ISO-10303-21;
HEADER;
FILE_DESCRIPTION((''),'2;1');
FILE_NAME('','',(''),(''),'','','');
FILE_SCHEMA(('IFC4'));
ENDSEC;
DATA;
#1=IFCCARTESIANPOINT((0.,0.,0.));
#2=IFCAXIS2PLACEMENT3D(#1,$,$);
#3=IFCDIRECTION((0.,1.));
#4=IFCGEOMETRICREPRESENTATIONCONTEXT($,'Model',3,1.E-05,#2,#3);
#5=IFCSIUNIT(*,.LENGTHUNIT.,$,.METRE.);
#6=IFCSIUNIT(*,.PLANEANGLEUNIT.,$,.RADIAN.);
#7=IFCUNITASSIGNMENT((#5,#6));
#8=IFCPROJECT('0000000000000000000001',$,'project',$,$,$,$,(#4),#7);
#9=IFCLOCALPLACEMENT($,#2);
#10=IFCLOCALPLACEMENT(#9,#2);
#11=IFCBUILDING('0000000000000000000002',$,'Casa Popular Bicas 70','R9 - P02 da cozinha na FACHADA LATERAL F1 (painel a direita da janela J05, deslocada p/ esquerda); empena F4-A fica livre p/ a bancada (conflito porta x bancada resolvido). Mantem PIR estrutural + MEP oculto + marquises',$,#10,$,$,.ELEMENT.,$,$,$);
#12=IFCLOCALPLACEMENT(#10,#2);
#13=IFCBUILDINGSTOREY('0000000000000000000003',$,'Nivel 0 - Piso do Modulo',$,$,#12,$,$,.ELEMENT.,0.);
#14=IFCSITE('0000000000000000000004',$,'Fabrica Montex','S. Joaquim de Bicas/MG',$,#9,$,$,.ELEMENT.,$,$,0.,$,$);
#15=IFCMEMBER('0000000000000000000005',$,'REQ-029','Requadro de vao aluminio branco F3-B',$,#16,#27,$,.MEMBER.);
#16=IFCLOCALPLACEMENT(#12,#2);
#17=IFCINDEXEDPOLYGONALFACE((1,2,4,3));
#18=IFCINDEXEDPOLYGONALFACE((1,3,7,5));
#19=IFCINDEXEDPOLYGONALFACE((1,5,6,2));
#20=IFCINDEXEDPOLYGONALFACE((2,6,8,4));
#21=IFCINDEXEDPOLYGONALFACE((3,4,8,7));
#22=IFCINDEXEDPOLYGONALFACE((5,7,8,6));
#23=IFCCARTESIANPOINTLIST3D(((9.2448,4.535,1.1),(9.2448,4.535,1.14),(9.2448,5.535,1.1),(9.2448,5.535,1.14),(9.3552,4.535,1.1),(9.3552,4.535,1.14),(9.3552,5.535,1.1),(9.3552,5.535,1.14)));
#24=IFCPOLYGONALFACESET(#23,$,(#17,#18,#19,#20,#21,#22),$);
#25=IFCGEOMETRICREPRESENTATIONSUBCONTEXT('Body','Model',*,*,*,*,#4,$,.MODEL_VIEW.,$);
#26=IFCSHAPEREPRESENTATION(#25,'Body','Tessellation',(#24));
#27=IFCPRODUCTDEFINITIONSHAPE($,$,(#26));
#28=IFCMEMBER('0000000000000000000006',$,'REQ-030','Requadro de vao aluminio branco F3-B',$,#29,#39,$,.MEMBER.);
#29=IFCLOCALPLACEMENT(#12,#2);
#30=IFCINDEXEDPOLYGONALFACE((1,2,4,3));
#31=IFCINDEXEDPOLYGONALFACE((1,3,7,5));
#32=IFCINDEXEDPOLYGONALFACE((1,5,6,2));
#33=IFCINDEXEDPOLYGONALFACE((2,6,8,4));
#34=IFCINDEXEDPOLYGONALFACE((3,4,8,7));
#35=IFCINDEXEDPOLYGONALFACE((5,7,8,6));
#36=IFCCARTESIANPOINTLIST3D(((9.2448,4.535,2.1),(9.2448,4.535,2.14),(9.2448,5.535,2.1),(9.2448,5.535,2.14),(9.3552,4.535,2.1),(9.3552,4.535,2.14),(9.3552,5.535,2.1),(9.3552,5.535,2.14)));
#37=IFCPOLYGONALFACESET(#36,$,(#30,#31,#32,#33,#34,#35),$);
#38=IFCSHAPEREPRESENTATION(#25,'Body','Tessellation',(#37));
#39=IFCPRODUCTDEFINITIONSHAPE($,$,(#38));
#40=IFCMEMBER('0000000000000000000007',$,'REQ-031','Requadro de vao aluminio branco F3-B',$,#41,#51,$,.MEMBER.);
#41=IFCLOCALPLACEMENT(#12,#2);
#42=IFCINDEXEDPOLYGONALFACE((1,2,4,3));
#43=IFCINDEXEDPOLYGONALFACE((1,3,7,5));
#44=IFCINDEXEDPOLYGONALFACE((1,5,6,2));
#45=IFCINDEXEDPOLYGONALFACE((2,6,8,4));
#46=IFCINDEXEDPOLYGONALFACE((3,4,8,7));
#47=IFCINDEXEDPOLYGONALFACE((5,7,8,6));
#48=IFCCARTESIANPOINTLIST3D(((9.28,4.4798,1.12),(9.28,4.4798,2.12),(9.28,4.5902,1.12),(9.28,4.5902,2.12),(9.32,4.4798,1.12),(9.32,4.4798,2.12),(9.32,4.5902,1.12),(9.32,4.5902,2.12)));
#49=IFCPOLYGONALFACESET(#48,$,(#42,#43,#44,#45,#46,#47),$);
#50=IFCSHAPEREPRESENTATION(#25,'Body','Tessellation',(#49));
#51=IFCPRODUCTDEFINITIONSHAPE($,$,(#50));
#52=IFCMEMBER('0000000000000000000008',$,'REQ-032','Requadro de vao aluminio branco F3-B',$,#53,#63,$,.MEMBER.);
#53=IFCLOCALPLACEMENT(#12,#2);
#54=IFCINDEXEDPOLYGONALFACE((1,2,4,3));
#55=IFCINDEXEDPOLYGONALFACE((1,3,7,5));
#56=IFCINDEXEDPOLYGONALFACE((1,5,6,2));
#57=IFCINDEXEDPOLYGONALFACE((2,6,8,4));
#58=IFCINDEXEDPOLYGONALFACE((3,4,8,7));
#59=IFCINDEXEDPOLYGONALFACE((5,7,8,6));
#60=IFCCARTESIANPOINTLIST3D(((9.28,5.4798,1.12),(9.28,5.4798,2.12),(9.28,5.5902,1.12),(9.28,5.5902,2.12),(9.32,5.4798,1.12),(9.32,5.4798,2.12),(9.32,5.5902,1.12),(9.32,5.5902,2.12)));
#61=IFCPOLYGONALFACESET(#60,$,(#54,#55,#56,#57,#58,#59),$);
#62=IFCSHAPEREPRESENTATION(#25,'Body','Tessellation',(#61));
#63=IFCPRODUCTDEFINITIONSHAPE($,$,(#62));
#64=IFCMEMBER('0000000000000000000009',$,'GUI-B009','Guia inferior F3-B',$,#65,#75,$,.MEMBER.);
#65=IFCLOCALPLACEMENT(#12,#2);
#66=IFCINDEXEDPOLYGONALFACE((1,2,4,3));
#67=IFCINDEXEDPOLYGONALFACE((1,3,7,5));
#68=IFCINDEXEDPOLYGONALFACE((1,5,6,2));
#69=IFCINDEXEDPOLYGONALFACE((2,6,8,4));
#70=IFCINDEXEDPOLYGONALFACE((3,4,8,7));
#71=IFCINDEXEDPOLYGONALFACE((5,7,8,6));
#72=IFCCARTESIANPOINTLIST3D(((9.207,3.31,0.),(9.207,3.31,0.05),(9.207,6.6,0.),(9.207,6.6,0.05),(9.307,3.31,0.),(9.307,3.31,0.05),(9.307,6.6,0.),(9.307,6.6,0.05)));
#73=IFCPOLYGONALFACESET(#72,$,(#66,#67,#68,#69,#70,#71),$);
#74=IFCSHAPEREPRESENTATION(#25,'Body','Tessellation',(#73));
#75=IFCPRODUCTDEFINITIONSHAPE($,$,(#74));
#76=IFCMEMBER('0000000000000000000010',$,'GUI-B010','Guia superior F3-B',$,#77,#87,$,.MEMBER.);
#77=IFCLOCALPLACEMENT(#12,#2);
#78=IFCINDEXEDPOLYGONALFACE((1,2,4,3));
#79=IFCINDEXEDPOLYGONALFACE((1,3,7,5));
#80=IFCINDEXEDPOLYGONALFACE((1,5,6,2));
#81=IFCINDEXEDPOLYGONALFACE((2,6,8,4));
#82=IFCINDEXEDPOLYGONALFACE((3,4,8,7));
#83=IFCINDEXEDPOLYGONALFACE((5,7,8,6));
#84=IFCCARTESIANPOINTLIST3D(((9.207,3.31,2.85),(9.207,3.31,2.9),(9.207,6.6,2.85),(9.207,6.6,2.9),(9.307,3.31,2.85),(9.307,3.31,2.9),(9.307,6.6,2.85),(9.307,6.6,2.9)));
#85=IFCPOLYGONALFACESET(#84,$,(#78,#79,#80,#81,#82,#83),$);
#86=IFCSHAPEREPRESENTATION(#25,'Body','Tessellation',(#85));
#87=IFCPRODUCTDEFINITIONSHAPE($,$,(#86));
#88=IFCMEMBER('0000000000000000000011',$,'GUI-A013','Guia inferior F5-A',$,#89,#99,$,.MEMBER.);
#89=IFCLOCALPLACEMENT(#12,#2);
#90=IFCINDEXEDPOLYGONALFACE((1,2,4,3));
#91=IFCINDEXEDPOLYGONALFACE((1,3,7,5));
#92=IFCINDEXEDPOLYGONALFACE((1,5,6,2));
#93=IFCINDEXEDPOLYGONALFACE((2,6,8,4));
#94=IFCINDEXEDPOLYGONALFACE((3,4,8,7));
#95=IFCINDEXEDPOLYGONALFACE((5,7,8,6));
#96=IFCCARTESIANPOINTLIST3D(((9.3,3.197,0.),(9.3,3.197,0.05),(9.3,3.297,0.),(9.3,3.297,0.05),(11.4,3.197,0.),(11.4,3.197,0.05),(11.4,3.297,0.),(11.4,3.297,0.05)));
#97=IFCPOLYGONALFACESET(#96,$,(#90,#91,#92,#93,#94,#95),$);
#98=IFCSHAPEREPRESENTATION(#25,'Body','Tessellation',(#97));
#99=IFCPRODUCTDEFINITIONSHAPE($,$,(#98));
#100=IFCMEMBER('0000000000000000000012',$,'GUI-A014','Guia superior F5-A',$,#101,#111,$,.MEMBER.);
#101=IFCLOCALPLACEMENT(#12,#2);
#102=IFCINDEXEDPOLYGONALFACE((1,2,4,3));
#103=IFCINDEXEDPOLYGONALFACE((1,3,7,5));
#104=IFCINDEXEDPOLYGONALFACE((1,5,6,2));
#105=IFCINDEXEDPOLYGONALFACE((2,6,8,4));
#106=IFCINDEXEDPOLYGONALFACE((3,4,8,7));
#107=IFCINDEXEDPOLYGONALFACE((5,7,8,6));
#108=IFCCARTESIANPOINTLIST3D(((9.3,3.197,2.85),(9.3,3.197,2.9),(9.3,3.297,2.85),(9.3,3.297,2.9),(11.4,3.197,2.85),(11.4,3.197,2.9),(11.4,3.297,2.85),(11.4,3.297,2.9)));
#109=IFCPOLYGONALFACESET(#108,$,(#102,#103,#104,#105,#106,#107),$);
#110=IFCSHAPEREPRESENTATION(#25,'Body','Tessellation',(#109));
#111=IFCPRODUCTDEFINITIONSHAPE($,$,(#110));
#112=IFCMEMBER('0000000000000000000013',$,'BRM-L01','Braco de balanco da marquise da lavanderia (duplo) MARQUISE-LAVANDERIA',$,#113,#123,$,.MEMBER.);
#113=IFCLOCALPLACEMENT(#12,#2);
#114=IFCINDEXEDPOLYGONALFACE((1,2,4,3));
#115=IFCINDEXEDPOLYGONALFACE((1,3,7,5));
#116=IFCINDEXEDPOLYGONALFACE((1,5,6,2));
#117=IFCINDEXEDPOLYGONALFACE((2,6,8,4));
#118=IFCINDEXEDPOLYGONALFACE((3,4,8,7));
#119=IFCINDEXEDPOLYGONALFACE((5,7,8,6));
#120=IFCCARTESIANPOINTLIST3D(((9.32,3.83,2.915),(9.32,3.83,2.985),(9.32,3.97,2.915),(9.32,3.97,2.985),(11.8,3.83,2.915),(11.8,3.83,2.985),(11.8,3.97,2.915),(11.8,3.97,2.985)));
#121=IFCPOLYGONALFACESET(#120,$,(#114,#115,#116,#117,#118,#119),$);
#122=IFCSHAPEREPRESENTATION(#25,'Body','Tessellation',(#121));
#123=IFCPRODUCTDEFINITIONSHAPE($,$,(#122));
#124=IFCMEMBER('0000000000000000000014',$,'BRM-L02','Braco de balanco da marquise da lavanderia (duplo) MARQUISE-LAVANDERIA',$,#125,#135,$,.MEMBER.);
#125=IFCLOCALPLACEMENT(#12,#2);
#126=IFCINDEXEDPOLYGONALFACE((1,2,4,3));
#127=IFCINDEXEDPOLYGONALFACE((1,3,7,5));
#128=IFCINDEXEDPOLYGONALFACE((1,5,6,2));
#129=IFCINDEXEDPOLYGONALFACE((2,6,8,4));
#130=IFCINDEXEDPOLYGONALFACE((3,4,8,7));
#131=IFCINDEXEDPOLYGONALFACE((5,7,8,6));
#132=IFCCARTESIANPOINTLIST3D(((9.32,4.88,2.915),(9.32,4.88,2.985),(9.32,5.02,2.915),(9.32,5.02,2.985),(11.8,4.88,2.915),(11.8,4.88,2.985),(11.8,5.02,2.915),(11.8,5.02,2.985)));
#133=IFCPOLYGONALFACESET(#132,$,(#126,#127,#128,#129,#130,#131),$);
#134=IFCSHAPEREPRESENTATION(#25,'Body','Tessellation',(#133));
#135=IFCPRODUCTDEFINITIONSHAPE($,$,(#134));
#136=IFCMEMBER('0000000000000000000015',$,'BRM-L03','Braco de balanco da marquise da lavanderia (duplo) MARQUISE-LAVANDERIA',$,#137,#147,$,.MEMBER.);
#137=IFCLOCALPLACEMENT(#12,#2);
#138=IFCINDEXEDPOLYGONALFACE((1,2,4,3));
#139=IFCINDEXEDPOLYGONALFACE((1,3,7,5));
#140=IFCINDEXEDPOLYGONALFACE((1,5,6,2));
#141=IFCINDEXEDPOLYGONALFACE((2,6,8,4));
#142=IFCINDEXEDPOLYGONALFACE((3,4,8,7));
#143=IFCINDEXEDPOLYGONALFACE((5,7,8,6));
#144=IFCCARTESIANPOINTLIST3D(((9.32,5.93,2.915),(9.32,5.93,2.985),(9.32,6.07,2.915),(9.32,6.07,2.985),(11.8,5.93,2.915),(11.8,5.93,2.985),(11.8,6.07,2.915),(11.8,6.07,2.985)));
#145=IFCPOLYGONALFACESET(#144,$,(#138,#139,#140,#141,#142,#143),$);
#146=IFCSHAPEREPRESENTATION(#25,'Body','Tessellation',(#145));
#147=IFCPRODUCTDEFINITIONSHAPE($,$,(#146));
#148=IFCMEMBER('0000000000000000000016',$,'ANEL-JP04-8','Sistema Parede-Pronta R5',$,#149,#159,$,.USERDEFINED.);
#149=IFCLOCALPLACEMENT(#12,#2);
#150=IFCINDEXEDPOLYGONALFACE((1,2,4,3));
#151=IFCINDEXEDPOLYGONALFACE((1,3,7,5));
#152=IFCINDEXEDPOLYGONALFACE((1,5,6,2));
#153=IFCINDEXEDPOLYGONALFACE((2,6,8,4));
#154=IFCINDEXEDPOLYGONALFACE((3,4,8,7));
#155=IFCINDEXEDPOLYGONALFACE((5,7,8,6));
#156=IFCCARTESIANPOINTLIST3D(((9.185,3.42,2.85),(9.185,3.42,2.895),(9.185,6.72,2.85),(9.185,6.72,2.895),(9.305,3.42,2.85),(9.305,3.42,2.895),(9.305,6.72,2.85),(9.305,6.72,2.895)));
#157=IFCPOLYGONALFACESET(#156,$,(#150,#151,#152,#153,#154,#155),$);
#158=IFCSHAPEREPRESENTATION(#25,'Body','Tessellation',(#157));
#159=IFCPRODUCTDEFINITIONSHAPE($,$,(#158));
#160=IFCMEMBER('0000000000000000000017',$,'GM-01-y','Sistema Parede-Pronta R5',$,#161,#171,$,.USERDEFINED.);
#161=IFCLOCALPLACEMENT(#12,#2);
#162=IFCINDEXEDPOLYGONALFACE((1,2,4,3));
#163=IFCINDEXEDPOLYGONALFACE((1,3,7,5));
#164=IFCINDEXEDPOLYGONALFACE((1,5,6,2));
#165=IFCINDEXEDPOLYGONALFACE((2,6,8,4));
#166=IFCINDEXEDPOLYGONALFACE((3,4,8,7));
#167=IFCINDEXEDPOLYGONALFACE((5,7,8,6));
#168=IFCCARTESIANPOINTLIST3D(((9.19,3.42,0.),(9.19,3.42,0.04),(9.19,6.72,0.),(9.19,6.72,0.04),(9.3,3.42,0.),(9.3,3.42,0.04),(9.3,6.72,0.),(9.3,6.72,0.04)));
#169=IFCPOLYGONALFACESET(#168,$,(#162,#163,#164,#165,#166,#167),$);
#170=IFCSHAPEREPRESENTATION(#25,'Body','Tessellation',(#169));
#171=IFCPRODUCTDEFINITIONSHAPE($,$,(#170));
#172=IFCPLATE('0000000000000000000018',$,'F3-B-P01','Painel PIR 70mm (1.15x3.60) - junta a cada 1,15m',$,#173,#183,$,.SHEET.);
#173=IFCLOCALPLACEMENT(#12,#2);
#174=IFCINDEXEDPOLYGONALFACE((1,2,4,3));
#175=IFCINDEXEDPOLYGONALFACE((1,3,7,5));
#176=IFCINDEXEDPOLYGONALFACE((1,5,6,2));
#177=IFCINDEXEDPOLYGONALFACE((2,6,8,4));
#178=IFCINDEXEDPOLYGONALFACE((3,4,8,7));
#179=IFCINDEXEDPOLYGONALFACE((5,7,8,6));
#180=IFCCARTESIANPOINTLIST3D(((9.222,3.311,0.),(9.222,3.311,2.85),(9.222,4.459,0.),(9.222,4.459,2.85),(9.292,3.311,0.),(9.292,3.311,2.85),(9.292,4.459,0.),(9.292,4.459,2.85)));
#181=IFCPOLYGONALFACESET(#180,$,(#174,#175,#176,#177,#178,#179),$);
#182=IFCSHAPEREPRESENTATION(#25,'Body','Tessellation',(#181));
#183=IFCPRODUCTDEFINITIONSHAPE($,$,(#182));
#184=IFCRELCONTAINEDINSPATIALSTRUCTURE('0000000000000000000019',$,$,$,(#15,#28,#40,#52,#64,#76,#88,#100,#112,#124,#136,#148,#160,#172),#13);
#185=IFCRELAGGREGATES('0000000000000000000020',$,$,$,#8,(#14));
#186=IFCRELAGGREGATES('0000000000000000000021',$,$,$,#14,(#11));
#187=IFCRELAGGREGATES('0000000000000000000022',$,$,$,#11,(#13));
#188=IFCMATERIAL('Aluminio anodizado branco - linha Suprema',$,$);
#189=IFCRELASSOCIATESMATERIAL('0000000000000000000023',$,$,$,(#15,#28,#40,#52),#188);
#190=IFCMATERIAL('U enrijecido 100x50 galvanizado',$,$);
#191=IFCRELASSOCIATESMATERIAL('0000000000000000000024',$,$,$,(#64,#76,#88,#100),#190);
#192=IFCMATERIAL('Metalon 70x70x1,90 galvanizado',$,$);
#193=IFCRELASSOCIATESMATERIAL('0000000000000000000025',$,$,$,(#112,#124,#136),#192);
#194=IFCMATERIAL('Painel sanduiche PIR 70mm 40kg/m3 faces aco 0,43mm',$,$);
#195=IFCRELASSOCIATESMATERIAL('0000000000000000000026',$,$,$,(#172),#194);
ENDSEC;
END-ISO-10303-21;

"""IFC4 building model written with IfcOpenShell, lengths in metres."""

from ifc_helpers import new_model, si_unit, direction, frame, frame_2d, origin, origin_2d, place, context, subcontext, project, spatial, rectangle, extrude, material, element, save


model = new_model("IFC4")

# Units and contexts
model_context = context("Model", 3, precision=1e-05, world=origin(), true_north=direction((0.0, 1.0)))
body_context = subcontext(model_context, "Body", "Model", "MODEL_VIEW")
ifc_project = project(units=[si_unit("LENGTHUNIT", "METRE"), si_unit("PLANEANGLEUNIT", "RADIAN")], contexts=[model_context])

# Site, building, storey
site_placement = place(None, origin())
site = spatial("IfcSite", under=ifc_project, at=site_placement, Name="Fabrica Montex", Description="S. Joaquim de Bicas/MG", CompositionType="ELEMENT", RefElevation=0.0)
building_placement = place(site_placement, origin())
building = spatial("IfcBuilding", under=site, at=building_placement, Name="Casa Popular Bicas 70", Description="R9 - P02 da cozinha na FACHADA LATERAL F1 (painel a direita da janela J05, deslocada p/ esquerda); empena F4-A fica livre p/ a bancada (conflito porta x bancada resolvido). Mantem PIR estrutural + MEP oculto + marquises", CompositionType="ELEMENT")
storey_placement = place(building_placement, origin())
storey = spatial("IfcBuildingStorey", under=building, at=storey_placement, Name="Nivel 0 - Piso do Modulo", CompositionType="ELEMENT", Elevation=0.0)

# Members
ifc_material_1 = material(Name="Aluminio anodizado branco - linha Suprema")
for number, where, z_axis, x_axis, name in (
    (1, (9.3, 4.535, 1.12), (0.0, 1.0, 0.0), (0.0, 0.0, 1.0), "REQ-029"),
    (2, (9.3, 4.535, 2.12), (0.0, 1.0, 0.0), (0.0, 0.0, 1.0), "REQ-030"),
    (3, (9.3, 4.535, 1.12), (0.0, 0.0, 1.0), (1.0, 0.0, 0.0), "REQ-031"),
    (4, (9.3, 5.535, 1.12), (0.0, 0.0, 1.0), (1.0, 0.0, 0.0), "REQ-032"),
):
    element("IfcMember", number, at=place(storey_placement, frame(where, z_axis=z_axis, x_axis=x_axis)), inside=storey, material=ifc_material_1, Name=name, Description="Requadro de vao aluminio branco F3-B", PredefinedType="MEMBER", context=body_context, shape_type="SweptSolid", body=[
        extrude(rectangle(XDim=0.04, YDim=0.1105, at=origin_2d()), origin(), (0.0, 0.0, 1.0), 1.0),
    ])
ifc_material_2 = material(Name="U enrijecido 100x50 galvanizado")
for number, where, z_axis, x_axis, name, description in (
    (5, (9.257, 3.31, 0.025), (0.0, 1.0, 0.0), (0.0, 0.0, 1.0), "GUI-B009", "Guia inferior F3-B"),
    (6, (9.257, 3.31, 2.875), (0.0, 1.0, 0.0), (0.0, 0.0, 1.0), "GUI-B010", "Guia superior F3-B"),
):
    element("IfcMember", number, at=place(storey_placement, frame(where, z_axis=z_axis, x_axis=x_axis)), inside=storey, material=ifc_material_2, Name=name, Description=description, PredefinedType="MEMBER", context=body_context, shape_type="SweptSolid", body=[
        extrude(rectangle(XDim=0.05, YDim=0.1, at=origin_2d()), origin(), (0.0, 0.0, 1.0), 3.29),
    ])
for number, where, z_axis, x_axis, name, description in (
    (7, (9.3, 3.247, 0.025), (1.0, 0.0, 0.0), (0.0, 0.0, 1.0), "GUI-A013", "Guia inferior F5-A"),
    (8, (9.3, 3.247, 2.875), (1.0, 0.0, 0.0), (0.0, 0.0, 1.0), "GUI-A014", "Guia superior F5-A"),
):
    element("IfcMember", number, at=place(storey_placement, frame(where, z_axis=z_axis, x_axis=x_axis)), inside=storey, material=ifc_material_2, Name=name, Description=description, PredefinedType="MEMBER", context=body_context, shape_type="SweptSolid", body=[
        extrude(rectangle(XDim=0.05, YDim=0.1, at=origin_2d()), origin(), (0.0, 0.0, 1.0), 2.1),
    ])
ifc_material_3 = material(Name="Metalon 70x70x1,90 galvanizado")
for number, where, z_axis, x_axis, name in (
    (9, (9.32, 3.9, 2.95), (1.0, 0.0, 0.0), (0.0, 0.0, 1.0), "BRM-L01"),
    (10, (9.32, 4.95, 2.95), (1.0, 0.0, 0.0), (0.0, 0.0, 1.0), "BRM-L02"),
    (11, (9.32, 6.0, 2.95), (1.0, 0.0, 0.0), (0.0, 0.0, 1.0), "BRM-L03"),
):
    element("IfcMember", number, at=place(storey_placement, frame(where, z_axis=z_axis, x_axis=x_axis)), inside=storey, material=ifc_material_3, Name=name, Description="Braco de balanco da marquise da lavanderia (duplo) MARQUISE-LAVANDERIA", PredefinedType="MEMBER", context=body_context, shape_type="SweptSolid", body=[
        extrude(rectangle(XDim=0.07, YDim=0.14, at=origin_2d()), origin(), (0.0, 0.0, 1.0), 2.48),
    ])
member_1_placement = place(storey_placement, frame((9.245, 5.07, 2.85)))
element("IfcMember", 12, at=member_1_placement, inside=storey, Name="ANEL-JP04-8", Description="Sistema Parede-Pronta R5", PredefinedType="USERDEFINED", context=body_context, shape_type="SweptSolid", body=[
    extrude(rectangle(XDim=0.12, YDim=3.3, at=origin_2d()), origin(), (0.0, 0.0, 1.0), 0.045),
])
member_2_placement = place(storey_placement, frame((9.245, 5.07, 0.0)))
element("IfcMember", 13, at=member_2_placement, inside=storey, Name="GM-01-y", Description="Sistema Parede-Pronta R5", PredefinedType="USERDEFINED", context=body_context, shape_type="SweptSolid", body=[
    extrude(rectangle(XDim=0.11, YDim=3.3, at=origin_2d()), origin(), (0.0, 0.0, 1.0), 0.04),
])

# Plate
ifc_material_4 = material(Name="Painel sanduiche PIR 70mm 40kg/m3 faces aco 0,43mm")
plate_1_placement = place(storey_placement, frame((9.257, 3.311, 0.0), x_axis=(0.0, 1.0, 0.0)))
element("IfcPlate", 14, at=plate_1_placement, inside=storey, material=ifc_material_4, Name="F3-B-P01", Description="Painel PIR 70mm (1.15x3.60) - junta a cada 1,15m", PredefinedType="SHEET", context=body_context, shape_type="SweptSolid", body=[
    extrude(rectangle(XDim=1.148, YDim=0.07, at=frame_2d((0.574, 0.0))), origin(), (0.0, 0.0, 1.0), 2.85),
])

save(model, "model.ifc")
